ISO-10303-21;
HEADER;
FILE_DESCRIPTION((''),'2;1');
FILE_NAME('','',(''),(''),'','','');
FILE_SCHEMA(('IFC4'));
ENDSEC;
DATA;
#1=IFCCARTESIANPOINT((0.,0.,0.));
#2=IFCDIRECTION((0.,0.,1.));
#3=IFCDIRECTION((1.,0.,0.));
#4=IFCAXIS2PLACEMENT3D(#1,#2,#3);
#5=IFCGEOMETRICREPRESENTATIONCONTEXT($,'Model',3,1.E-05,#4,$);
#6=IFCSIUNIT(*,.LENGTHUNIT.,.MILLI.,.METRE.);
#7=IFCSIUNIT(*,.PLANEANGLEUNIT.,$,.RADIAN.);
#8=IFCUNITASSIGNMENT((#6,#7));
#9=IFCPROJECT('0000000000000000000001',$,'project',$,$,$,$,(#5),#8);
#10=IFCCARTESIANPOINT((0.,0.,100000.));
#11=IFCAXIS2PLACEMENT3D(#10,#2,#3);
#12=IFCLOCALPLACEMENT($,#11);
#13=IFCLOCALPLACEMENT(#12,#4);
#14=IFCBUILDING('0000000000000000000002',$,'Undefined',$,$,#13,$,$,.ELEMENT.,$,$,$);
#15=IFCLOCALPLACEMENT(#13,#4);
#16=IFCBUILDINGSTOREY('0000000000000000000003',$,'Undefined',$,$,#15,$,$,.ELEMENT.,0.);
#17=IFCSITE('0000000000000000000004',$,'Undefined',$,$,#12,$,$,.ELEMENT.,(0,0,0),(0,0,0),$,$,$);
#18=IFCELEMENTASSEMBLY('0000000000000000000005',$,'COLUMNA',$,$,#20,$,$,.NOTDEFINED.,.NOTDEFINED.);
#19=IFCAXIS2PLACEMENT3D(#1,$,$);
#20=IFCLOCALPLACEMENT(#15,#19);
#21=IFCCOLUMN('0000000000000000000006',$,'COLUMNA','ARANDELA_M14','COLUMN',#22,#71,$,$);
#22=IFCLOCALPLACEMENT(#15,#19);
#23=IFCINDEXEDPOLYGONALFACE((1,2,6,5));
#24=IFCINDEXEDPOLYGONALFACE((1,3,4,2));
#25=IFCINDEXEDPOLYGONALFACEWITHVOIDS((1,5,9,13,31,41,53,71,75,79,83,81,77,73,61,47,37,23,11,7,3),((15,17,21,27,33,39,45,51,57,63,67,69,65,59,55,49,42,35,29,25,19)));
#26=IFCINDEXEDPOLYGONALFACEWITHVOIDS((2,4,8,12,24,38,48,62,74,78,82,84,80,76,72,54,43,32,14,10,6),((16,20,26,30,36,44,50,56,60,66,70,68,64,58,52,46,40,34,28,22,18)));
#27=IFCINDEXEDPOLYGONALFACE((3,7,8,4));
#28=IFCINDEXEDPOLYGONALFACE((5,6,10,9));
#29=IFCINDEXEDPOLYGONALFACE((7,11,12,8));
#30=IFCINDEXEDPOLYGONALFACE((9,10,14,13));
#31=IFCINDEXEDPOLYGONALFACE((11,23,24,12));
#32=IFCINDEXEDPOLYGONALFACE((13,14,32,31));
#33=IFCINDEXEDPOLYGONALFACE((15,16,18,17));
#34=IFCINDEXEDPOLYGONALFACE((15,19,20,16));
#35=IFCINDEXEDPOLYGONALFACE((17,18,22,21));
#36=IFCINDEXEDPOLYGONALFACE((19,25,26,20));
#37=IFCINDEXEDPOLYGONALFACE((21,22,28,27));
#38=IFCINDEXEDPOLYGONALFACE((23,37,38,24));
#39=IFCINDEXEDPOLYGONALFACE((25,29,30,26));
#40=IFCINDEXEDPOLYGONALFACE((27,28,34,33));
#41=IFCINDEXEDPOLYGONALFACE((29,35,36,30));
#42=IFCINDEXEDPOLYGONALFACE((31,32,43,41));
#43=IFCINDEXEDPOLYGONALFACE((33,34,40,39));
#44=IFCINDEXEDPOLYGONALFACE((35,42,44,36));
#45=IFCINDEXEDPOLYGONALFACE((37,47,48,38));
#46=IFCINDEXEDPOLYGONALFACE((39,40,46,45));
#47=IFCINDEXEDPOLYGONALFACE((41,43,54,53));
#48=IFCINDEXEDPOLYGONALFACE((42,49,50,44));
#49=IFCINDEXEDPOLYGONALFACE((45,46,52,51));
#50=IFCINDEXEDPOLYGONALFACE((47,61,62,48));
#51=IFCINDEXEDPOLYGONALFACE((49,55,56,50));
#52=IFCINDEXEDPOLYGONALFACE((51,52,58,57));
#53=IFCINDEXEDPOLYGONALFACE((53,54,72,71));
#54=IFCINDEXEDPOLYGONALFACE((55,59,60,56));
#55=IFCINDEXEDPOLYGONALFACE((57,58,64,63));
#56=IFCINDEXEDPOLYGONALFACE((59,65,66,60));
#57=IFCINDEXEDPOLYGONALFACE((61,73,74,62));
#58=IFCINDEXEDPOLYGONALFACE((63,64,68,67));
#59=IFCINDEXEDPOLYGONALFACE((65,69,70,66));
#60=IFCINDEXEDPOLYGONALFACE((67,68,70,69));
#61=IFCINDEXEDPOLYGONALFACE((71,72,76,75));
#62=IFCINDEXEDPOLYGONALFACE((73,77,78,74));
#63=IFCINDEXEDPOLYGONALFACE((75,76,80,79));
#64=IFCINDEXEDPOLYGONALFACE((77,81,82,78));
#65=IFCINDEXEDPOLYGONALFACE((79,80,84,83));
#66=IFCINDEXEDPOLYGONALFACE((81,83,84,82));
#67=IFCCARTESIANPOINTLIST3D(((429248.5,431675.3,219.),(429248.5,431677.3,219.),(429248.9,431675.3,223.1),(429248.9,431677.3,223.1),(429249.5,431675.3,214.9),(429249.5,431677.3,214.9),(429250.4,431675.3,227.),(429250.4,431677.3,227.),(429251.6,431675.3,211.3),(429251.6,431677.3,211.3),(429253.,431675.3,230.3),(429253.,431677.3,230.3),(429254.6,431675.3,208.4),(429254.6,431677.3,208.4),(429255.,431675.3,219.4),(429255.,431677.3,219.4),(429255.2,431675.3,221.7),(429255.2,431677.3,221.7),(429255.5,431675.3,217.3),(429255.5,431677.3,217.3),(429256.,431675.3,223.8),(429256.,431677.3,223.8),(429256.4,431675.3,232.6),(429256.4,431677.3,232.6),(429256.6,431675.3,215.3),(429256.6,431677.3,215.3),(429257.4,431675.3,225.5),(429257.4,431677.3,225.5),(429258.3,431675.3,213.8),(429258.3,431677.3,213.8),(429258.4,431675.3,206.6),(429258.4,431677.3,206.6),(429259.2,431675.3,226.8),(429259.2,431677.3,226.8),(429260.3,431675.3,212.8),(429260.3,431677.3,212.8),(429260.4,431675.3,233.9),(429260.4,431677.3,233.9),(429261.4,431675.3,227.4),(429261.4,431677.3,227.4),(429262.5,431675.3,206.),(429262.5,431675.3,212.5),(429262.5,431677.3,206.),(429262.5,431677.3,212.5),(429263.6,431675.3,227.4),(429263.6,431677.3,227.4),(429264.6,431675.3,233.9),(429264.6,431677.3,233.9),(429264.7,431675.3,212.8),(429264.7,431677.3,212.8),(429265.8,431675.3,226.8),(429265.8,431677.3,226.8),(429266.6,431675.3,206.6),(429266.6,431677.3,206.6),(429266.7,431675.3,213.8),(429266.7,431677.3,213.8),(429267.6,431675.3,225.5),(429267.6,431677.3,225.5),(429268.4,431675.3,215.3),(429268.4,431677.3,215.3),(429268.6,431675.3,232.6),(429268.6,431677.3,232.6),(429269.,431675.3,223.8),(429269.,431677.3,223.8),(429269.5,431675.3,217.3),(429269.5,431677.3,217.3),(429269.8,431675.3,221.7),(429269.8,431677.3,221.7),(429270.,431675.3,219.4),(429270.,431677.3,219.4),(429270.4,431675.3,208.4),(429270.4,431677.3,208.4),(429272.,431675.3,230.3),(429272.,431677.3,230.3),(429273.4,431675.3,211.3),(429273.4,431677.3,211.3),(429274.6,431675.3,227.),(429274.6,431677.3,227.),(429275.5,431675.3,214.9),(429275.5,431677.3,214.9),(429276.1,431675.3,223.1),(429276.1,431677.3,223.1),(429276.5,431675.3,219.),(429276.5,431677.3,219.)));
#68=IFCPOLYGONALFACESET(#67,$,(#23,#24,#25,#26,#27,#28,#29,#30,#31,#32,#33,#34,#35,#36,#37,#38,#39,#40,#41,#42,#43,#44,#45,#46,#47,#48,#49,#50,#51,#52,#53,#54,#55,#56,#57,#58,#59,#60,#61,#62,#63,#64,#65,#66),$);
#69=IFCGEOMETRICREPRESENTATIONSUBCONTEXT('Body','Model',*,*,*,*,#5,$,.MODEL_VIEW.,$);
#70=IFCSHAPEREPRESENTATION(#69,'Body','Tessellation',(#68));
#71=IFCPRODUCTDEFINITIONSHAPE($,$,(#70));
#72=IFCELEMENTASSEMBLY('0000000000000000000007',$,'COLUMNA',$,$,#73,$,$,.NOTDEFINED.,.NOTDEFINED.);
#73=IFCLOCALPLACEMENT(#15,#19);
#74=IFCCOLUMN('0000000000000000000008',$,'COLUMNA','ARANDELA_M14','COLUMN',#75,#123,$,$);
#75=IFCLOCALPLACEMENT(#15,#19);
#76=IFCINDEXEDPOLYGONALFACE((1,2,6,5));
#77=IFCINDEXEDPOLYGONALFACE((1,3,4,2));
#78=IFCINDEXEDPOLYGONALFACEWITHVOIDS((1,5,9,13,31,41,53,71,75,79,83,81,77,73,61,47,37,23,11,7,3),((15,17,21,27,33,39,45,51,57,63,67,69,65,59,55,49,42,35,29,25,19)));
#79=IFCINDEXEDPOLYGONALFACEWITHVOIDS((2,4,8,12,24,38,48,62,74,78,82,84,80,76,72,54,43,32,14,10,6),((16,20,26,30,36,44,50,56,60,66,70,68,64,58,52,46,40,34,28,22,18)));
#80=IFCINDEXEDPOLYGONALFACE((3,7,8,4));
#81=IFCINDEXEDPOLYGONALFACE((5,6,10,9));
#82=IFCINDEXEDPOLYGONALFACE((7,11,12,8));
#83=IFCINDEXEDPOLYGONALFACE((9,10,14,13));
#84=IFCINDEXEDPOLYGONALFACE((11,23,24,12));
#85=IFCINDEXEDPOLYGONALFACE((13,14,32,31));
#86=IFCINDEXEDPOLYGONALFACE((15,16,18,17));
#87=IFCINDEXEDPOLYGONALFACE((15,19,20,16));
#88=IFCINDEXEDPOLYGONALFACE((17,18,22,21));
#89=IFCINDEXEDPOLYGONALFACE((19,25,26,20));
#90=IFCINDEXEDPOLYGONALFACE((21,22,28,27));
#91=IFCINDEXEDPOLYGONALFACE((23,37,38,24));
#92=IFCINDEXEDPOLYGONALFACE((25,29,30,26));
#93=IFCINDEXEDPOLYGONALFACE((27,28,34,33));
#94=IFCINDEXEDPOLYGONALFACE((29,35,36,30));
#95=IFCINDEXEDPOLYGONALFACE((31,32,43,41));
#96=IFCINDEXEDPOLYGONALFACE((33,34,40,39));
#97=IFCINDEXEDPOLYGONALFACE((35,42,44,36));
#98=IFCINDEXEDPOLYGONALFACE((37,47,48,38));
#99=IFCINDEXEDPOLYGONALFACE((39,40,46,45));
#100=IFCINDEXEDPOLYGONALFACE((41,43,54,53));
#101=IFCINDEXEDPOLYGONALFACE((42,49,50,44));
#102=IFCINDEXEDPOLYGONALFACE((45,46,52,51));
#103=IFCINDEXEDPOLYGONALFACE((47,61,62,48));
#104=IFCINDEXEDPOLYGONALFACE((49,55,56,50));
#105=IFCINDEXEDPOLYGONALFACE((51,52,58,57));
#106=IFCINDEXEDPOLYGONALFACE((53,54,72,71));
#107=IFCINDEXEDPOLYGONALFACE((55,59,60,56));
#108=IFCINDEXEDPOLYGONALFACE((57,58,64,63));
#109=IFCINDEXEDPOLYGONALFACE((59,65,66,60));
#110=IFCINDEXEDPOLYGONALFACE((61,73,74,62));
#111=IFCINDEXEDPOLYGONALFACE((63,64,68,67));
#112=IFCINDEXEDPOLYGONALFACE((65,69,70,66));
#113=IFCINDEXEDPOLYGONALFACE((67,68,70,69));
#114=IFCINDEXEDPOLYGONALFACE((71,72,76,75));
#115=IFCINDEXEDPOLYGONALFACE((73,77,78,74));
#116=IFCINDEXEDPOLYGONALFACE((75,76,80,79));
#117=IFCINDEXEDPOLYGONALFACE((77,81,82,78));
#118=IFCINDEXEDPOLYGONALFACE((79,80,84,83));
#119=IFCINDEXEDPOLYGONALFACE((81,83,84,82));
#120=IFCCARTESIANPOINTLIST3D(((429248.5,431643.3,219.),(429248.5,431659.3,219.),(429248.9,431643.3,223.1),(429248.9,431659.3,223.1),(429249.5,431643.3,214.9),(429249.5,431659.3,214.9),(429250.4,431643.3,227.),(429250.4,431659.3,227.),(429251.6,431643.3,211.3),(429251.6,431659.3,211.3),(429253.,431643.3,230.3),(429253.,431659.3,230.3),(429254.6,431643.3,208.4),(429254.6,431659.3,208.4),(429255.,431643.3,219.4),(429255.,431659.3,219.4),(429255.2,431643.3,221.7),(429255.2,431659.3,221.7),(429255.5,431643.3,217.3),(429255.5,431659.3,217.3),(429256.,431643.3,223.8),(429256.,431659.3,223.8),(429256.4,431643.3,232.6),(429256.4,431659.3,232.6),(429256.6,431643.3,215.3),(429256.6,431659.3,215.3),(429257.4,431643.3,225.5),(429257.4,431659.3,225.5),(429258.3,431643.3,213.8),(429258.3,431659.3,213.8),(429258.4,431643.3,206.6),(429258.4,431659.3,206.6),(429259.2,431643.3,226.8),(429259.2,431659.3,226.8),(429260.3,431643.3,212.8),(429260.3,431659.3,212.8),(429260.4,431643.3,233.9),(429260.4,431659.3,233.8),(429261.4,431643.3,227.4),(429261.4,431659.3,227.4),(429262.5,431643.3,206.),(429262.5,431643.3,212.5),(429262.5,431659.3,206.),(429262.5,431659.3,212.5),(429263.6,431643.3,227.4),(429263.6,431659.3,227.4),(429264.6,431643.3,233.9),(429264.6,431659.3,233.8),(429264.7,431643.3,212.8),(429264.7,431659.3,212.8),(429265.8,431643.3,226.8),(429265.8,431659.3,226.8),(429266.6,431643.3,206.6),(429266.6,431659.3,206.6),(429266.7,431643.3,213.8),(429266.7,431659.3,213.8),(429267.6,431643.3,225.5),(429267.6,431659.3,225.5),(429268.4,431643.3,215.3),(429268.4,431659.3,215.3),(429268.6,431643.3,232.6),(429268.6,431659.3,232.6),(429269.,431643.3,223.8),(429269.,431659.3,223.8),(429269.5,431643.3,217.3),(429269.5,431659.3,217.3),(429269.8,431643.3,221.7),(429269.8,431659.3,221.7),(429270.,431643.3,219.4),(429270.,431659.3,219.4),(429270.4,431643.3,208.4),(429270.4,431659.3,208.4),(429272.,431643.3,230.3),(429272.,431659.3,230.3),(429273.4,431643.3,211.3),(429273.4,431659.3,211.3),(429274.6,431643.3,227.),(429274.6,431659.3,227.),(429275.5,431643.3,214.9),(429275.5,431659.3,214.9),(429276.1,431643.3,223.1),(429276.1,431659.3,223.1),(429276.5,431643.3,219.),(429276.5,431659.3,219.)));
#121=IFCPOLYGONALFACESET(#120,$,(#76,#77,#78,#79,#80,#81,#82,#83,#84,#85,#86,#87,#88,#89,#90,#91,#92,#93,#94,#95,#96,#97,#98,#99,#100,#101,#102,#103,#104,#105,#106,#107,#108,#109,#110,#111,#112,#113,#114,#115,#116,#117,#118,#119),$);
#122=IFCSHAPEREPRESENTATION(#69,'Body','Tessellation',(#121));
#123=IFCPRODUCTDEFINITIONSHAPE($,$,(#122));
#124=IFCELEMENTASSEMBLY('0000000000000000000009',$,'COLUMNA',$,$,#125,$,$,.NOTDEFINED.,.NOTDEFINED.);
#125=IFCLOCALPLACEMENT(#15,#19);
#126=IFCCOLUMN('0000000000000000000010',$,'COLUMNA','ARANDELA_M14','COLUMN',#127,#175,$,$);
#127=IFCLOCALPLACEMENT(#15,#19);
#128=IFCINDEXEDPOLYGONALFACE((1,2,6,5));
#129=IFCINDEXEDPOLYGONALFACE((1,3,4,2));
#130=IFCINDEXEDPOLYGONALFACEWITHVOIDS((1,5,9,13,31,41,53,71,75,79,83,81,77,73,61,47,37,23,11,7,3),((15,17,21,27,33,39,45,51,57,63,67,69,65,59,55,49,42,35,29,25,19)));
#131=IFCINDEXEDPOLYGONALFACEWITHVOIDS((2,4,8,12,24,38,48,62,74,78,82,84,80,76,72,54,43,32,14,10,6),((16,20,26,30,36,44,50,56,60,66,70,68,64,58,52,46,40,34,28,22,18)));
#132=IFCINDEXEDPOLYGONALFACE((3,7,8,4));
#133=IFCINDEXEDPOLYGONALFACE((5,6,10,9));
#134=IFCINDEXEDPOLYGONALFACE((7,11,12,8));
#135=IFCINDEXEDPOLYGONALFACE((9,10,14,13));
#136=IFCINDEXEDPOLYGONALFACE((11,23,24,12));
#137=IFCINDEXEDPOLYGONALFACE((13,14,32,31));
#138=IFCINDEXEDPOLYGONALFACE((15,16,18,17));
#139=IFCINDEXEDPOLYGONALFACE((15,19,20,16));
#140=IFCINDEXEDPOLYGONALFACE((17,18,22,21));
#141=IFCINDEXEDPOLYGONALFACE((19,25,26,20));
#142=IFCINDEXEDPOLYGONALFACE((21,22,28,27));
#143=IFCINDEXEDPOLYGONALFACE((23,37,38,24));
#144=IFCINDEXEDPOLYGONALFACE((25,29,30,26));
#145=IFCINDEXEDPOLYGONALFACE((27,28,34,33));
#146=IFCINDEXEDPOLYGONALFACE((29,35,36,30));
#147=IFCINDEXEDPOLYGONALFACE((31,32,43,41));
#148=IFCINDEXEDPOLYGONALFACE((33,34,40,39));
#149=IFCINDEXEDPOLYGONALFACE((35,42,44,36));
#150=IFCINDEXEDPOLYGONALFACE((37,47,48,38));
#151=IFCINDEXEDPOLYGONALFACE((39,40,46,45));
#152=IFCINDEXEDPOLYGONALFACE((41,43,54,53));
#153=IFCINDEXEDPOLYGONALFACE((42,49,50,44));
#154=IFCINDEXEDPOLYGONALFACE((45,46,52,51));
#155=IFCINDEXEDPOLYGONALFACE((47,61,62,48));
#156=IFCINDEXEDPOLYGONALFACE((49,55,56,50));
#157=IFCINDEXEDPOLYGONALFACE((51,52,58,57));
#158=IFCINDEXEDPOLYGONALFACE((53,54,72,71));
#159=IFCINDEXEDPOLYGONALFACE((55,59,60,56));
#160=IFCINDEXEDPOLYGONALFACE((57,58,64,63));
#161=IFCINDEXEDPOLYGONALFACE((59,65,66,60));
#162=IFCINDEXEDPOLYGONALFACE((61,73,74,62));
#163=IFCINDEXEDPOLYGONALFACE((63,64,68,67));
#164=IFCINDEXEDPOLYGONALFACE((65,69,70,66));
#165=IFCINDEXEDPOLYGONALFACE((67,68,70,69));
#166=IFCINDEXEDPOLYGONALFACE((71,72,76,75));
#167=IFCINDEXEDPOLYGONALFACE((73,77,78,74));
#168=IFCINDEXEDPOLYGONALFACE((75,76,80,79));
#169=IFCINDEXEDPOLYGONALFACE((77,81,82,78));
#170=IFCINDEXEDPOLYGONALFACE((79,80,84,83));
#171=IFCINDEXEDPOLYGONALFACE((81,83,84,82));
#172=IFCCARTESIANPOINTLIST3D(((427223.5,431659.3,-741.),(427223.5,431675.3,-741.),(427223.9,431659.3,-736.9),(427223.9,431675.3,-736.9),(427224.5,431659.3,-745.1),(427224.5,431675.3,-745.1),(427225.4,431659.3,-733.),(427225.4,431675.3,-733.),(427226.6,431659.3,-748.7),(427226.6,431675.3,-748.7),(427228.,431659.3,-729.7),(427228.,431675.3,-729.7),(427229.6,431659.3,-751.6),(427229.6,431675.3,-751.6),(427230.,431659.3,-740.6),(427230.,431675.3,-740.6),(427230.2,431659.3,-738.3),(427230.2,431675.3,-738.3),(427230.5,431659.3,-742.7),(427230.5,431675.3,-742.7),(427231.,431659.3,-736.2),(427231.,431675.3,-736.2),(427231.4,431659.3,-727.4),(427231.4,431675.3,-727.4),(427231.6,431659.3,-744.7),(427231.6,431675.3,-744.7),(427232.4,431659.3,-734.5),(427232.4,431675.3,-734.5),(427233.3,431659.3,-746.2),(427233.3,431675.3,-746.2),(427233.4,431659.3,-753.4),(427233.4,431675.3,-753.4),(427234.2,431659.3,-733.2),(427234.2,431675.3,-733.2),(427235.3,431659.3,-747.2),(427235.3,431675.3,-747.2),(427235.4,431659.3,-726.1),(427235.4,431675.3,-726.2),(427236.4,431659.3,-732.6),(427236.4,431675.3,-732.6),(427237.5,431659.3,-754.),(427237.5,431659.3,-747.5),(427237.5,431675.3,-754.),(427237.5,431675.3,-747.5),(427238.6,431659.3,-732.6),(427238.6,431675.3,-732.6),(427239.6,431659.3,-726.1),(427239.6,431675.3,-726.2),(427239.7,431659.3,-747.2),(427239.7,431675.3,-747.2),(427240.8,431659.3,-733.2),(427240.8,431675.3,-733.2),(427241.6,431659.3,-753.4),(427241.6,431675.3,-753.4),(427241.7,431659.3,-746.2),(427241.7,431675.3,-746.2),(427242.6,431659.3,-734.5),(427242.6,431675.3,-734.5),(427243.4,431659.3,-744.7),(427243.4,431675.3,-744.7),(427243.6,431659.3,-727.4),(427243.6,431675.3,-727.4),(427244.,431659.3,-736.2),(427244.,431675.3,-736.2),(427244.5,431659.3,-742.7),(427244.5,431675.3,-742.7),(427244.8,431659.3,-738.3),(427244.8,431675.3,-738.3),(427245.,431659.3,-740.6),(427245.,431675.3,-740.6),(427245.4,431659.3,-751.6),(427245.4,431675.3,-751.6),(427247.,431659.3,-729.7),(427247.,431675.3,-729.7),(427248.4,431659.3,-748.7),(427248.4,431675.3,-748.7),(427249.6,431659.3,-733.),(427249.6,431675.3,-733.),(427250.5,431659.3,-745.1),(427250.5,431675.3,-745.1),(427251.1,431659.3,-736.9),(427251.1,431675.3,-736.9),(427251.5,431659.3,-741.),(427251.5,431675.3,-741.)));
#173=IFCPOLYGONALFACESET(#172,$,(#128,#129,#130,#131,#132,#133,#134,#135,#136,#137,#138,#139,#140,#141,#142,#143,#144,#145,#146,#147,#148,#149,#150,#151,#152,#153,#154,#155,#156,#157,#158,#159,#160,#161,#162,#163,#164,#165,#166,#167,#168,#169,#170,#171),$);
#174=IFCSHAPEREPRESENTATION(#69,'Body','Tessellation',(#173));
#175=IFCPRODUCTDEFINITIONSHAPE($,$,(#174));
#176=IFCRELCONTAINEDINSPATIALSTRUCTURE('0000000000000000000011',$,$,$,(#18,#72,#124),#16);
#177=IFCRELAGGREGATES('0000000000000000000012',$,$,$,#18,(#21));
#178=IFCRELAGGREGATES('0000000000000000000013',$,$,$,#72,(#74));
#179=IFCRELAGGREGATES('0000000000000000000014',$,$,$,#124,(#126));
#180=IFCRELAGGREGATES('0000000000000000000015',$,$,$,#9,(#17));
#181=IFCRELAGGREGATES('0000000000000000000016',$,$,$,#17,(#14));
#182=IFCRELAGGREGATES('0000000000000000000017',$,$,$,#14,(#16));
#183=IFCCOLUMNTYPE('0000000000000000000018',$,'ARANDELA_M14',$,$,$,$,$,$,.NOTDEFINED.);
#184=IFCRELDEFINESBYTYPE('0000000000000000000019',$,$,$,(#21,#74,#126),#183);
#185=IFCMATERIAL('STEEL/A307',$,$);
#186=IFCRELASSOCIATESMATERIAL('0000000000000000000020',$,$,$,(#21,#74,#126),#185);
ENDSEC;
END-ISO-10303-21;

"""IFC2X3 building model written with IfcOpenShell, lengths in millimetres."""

from ifc_helpers import new_model, si_unit, frame, origin_with_axes, origin_2d_with_axis, place, context, subcontext, project, spatial, hollow_circle, extrude, material, type_object, element, aggregate, save


model = new_model("IFC2X3")

# Units and contexts
model_context = context("Model", 3, precision=1e-05, world=origin_with_axes())
body_context = subcontext(model_context, "Body", "Model", "MODEL_VIEW")
ifc_project = project(units=[si_unit("LENGTHUNIT", "METRE", prefix="MILLI"), si_unit("PLANEANGLEUNIT", "RADIAN")], contexts=[model_context])

# Site, building, storey
site_placement = place(None, frame((0.0, 0.0, 100000.0), z_axis=(0.0, 0.0, 1.0), x_axis=(1.0, 0.0, 0.0)))
site = spatial("IfcSite", under=ifc_project, at=site_placement, Name="Undefined", CompositionType="ELEMENT", RefLatitude=(0, 0, 0), RefLongitude=(0, 0, 0))
building_placement = place(site_placement, origin_with_axes())
building = spatial("IfcBuilding", under=site, at=building_placement, Name="Undefined", CompositionType="ELEMENT")
storey_placement = place(building_placement, origin_with_axes())
storey = spatial("IfcBuildingStorey", under=building, at=storey_placement, Name="Undefined", CompositionType="ELEMENT", Elevation=0.0)

# Element assemblies, columns
ifc_material_1 = material(Name="STEEL/A307")
column_type_1 = type_object("IfcColumnType", Name="ARANDELA_M14", PredefinedType="NOTDEFINED")
assembly_1_placement = place(storey_placement, origin_with_axes())
assembly_1 = element("IfcElementAssembly", 1, at=assembly_1_placement, inside=storey, Name="COLUMNA", AssemblyPlace="NOTDEFINED", PredefinedType="NOTDEFINED")
column_1_placement = place(assembly_1_placement, frame((429262.5, 431677.3, 220.0), z_axis=(0.0, -1.0, 0.000285), x_axis=(-1.0, 0.0, 0.0)))
column_1 = element("IfcColumn", 2, at=column_1_placement, type_object=column_type_1, material=ifc_material_1, Name="COLUMNA", Description="ARANDELA_M14", ObjectType="COLUMN", context=body_context, shape_type="SweptSolid", body=[
    extrude(hollow_circle(Radius=14.0, WallThickness=6.5, at=origin_2d_with_axis()), frame((0.0, 0.0, 2.0), z_axis=(0.0, 0.0, -1.0), x_axis=(0.0, 1.0, 0.0)), (0.0, 0.0, 1.0), 2.0),
])
aggregate(assembly_1, [column_1])
assembly_2_placement = place(storey_placement, origin_with_axes())
assembly_2 = element("IfcElementAssembly", 3, at=assembly_2_placement, inside=storey, Name="COLUMNA", AssemblyPlace="NOTDEFINED", PredefinedType="NOTDEFINED")
column_2_placement = place(assembly_2_placement, frame((429262.5, 431659.3, 220.0), z_axis=(0.0, -1.0, 0.000285), x_axis=(-1.0, 0.0, 0.0)))
column_2 = element("IfcColumn", 4, at=column_2_placement, type_object=column_type_1, material=ifc_material_1, Name="COLUMNA", Description="ARANDELA_M14", ObjectType="COLUMN", context=body_context, shape_type="SweptSolid", body=[
    extrude(hollow_circle(Radius=14.0, WallThickness=6.5, at=origin_2d_with_axis()), frame((0.0, 0.0, 16.0), z_axis=(0.0, 0.0, -1.0), x_axis=(0.0, 1.0, 0.0)), (0.0, 0.0, 1.0), 16.0),
])
aggregate(assembly_2, [column_2])
assembly_3_placement = place(storey_placement, origin_with_axes())
assembly_3 = element("IfcElementAssembly", 5, at=assembly_3_placement, inside=storey, Name="COLUMNA", AssemblyPlace="NOTDEFINED", PredefinedType="NOTDEFINED")
column_3_placement = place(assembly_3_placement, frame((427237.5, 431675.3, -740.0), z_axis=(0.0, -1.0, 0.000285), x_axis=(-1.0, 0.0, 0.0)))
column_3 = element("IfcColumn", 6, at=column_3_placement, type_object=column_type_1, material=ifc_material_1, Name="COLUMNA", Description="ARANDELA_M14", ObjectType="COLUMN", context=body_context, shape_type="SweptSolid", body=[
    extrude(hollow_circle(Radius=14.0, WallThickness=6.5, at=origin_2d_with_axis()), frame((0.0, 0.0, 16.0), z_axis=(0.0, 0.0, -1.0), x_axis=(0.0, 1.0, 0.0)), (0.0, 0.0, 1.0), 16.0),
])
aggregate(assembly_3, [column_3])

save(model, "model.ifc")
